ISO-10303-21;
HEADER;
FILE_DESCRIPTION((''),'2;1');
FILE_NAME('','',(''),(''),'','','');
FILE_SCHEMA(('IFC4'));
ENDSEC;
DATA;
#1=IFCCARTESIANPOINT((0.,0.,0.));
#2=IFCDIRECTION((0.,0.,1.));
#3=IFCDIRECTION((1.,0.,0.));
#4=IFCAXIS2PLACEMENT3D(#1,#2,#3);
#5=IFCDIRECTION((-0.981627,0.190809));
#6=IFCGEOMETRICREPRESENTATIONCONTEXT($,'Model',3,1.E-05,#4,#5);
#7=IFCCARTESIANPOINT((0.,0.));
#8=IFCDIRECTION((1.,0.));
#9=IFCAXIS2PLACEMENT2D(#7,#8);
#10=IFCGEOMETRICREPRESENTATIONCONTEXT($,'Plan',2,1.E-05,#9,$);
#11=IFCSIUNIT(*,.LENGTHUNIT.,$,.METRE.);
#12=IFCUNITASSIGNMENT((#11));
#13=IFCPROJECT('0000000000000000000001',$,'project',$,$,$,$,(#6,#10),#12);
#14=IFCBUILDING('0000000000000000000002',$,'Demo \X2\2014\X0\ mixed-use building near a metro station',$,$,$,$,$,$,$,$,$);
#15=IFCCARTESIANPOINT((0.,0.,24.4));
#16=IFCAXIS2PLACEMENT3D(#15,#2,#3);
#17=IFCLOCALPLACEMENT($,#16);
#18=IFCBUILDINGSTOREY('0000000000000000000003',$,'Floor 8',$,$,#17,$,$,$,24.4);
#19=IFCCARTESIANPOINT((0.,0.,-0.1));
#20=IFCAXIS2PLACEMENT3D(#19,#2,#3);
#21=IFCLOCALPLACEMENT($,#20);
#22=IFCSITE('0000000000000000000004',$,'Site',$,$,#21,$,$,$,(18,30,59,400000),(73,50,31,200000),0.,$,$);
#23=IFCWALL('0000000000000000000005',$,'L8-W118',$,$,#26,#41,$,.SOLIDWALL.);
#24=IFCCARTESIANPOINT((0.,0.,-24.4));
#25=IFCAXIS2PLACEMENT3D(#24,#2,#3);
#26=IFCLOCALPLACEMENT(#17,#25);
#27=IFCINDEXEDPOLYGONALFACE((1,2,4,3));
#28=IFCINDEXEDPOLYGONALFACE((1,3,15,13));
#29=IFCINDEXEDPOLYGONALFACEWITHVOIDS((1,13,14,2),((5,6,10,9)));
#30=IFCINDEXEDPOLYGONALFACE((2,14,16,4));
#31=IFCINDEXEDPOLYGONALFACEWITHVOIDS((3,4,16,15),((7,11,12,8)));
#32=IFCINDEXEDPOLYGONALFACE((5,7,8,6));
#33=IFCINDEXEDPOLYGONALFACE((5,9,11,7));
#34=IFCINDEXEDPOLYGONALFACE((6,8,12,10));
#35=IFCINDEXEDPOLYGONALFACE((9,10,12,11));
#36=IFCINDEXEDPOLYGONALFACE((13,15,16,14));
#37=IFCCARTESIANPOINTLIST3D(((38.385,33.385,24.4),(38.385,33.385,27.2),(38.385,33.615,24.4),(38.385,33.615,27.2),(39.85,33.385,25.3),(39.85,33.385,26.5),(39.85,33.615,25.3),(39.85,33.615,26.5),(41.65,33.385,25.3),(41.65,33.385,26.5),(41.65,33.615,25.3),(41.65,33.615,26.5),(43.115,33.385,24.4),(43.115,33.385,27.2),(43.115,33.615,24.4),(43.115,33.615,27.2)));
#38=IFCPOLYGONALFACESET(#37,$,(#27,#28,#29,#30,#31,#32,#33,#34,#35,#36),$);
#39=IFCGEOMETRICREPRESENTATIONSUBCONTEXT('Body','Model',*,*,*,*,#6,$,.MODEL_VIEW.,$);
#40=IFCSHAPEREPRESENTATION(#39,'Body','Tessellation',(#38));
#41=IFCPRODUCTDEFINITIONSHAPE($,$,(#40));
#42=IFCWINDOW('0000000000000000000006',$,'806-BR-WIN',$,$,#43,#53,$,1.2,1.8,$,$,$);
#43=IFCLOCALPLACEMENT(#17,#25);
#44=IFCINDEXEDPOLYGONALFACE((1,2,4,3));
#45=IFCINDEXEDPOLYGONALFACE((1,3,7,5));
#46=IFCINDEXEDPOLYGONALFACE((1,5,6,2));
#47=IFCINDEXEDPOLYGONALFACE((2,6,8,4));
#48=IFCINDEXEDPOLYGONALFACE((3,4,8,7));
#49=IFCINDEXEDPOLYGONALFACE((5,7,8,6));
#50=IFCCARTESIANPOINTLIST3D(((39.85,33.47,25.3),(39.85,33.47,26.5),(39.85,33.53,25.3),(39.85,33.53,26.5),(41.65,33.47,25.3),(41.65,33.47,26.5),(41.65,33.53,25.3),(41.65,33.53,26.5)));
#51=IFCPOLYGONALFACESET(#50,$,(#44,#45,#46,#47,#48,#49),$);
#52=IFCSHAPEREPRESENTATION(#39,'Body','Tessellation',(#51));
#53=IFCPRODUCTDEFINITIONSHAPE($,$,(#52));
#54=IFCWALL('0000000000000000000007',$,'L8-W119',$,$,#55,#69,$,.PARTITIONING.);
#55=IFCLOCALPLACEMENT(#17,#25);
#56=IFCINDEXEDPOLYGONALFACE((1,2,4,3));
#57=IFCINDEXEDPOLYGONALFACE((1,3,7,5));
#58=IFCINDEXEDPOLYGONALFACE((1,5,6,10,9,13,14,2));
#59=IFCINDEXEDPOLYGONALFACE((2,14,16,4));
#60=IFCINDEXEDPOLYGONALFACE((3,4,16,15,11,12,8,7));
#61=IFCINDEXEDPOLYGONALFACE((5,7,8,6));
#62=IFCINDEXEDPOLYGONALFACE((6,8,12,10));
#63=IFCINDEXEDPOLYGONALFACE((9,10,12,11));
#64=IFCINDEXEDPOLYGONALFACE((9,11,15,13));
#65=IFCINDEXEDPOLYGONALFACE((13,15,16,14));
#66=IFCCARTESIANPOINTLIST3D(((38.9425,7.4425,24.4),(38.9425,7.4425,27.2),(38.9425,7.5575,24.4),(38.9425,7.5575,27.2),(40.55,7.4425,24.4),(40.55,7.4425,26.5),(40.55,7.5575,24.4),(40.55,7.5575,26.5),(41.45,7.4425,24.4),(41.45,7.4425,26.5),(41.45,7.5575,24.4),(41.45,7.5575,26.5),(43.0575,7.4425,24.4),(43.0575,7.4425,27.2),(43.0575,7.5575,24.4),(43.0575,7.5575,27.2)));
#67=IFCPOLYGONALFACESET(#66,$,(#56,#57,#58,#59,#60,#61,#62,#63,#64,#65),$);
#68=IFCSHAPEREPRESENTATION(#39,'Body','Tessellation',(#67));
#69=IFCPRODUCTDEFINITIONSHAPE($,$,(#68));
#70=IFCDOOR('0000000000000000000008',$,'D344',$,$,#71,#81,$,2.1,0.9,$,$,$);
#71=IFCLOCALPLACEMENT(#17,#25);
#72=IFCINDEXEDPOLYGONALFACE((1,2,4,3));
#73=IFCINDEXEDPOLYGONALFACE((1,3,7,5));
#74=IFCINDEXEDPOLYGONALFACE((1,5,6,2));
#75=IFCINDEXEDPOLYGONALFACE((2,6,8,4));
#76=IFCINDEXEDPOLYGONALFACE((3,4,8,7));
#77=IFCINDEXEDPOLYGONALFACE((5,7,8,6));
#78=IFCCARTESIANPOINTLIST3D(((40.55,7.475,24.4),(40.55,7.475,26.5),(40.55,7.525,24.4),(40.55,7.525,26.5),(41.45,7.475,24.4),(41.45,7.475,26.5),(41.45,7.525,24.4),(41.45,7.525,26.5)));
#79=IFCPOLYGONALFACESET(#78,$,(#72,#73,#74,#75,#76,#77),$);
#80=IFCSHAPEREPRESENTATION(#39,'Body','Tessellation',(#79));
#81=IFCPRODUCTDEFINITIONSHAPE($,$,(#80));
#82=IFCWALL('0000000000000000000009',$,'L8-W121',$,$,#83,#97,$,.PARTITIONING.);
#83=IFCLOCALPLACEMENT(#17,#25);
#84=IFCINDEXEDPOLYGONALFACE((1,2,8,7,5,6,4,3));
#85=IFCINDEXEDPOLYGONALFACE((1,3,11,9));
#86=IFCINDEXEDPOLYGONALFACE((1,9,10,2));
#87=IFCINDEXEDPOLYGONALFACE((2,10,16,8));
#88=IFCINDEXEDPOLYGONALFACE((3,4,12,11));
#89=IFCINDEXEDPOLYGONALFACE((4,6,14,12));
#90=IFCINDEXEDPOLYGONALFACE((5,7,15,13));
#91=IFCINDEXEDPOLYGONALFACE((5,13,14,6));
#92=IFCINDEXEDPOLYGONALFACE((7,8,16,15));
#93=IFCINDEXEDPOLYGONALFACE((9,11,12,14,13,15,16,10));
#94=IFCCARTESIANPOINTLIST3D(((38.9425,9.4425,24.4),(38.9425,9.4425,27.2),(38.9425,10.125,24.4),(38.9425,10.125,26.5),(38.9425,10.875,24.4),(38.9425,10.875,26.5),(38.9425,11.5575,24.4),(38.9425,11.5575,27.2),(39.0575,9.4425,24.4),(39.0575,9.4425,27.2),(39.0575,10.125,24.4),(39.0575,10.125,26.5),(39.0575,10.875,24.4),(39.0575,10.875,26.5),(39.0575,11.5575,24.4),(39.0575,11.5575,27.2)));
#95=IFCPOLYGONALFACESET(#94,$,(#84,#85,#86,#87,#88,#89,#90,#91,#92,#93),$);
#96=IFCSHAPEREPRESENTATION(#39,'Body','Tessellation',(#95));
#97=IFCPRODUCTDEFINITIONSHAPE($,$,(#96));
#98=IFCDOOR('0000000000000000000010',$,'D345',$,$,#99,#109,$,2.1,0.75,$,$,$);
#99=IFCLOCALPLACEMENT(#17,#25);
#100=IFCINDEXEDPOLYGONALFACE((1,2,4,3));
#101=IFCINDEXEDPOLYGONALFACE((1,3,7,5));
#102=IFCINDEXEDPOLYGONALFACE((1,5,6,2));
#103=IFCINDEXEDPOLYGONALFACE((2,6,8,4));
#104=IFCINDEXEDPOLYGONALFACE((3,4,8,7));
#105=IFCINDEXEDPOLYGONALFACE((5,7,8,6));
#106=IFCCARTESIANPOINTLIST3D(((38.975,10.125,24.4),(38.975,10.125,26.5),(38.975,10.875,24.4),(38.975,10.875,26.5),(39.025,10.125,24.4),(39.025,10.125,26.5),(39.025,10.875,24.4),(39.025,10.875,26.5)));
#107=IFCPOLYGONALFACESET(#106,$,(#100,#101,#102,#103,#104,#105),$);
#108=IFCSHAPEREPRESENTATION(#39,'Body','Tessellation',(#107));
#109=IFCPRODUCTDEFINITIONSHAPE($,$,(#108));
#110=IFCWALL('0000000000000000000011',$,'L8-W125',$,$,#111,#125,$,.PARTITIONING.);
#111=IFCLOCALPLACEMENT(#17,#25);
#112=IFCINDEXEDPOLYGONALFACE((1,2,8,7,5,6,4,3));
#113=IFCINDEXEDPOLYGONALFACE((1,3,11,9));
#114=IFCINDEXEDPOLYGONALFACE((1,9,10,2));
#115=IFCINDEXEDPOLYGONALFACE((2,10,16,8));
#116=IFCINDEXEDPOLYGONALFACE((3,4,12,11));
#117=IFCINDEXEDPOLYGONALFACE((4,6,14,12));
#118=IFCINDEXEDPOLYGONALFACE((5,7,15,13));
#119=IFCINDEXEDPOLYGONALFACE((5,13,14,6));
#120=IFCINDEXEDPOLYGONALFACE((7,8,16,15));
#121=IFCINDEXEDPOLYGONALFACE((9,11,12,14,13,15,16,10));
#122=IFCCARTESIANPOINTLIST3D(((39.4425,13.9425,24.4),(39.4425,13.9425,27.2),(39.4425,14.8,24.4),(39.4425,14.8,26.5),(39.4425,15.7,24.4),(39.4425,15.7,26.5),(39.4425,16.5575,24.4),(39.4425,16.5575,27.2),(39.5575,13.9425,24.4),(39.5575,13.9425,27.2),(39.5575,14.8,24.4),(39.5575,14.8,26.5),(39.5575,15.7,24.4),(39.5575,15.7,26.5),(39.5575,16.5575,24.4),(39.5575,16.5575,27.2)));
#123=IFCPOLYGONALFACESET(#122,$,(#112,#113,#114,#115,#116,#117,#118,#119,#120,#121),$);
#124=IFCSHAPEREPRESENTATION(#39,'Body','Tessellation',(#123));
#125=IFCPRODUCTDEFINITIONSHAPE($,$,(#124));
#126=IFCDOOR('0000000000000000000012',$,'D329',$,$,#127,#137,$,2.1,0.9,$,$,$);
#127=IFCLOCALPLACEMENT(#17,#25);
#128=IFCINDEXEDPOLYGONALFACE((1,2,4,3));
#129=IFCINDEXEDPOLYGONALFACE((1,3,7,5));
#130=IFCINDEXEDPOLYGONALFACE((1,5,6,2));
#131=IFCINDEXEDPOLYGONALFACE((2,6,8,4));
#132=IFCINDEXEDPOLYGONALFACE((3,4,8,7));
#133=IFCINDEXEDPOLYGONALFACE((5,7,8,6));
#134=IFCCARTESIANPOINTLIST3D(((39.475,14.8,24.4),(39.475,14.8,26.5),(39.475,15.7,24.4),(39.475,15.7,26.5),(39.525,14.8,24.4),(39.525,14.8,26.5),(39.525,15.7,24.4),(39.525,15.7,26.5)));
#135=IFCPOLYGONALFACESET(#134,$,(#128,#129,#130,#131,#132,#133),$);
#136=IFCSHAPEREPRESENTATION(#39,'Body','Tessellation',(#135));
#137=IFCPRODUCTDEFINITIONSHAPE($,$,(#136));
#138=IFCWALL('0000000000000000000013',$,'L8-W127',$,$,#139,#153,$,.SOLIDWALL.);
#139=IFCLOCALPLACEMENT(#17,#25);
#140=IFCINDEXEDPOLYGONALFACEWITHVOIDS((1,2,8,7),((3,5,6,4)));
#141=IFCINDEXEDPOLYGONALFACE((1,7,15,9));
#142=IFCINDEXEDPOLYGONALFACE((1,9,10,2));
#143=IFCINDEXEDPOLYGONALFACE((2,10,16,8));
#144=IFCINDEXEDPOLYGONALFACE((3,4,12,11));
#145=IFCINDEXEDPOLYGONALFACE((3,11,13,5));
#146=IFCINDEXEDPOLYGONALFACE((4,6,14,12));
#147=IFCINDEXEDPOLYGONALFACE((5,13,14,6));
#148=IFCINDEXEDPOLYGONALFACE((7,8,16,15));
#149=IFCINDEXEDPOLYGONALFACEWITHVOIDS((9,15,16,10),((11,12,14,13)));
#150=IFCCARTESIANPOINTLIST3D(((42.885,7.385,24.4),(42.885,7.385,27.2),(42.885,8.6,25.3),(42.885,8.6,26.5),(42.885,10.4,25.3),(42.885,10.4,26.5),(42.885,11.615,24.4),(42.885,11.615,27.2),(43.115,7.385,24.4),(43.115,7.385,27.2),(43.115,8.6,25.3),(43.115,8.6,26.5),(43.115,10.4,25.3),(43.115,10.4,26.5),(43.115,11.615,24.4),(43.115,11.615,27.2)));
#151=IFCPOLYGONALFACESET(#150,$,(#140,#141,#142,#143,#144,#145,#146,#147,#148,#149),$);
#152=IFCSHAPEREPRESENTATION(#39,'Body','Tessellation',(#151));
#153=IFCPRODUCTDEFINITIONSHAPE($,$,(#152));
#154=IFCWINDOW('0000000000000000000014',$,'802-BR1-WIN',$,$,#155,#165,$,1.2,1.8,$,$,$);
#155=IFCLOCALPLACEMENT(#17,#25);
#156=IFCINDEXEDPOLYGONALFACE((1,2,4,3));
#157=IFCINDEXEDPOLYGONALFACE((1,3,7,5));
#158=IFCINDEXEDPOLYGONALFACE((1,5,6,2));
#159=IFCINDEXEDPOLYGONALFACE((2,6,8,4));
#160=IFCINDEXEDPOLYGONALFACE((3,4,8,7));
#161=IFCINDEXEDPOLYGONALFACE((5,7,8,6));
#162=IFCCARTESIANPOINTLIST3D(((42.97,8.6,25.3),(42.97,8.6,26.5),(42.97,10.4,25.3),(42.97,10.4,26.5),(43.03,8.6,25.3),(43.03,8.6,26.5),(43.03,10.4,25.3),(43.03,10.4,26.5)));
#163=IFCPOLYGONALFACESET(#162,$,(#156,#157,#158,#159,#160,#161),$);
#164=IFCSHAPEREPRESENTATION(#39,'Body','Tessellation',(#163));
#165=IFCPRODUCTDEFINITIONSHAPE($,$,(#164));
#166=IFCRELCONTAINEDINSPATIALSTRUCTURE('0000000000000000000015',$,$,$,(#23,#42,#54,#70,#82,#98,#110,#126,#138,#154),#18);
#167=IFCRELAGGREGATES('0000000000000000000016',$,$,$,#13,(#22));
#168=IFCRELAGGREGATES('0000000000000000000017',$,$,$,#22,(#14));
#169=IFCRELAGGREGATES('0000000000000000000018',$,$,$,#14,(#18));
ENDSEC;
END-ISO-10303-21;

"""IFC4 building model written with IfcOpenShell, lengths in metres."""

from ifc_helpers import new_model, si_unit, direction, frame, origin_with_axes, origin_2d_with_axis, place, context, subcontext, project, spatial, line, indexed_curve, outline, extrude, element, fill, save


model = new_model("IFC4")

# Units and contexts
model_context = context("Model", 3, precision=1e-05, world=origin_with_axes(), true_north=direction((-0.981627, 0.190809)))
plan_context = context("Plan", 2, precision=1e-05, world=origin_2d_with_axis())
body_context = subcontext(model_context, "Body", "Model", "MODEL_VIEW")
ifc_project = project(units=[si_unit("LENGTHUNIT", "METRE")], contexts=[model_context, plan_context])

# Site, building, storey
site_placement = place(None, frame((0.0, 0.0, -0.1), z_axis=(0.0, 0.0, 1.0), x_axis=(1.0, 0.0, 0.0)))
site = spatial("IfcSite", under=ifc_project, at=site_placement, Name="Site", RefLatitude=(18, 30, 59, 400000), RefLongitude=(73, 50, 31, 200000), RefElevation=0.0)
building = spatial("IfcBuilding", under=site, Name="Demo — mixed-use building near a metro station")
storey_placement = place(None, frame((0.0, 0.0, 24.4), z_axis=(0.0, 0.0, 1.0), x_axis=(1.0, 0.0, 0.0)))
storey = spatial("IfcBuildingStorey", under=building, at=storey_placement, Name="Floor 8", Elevation=24.4)

# Wall, opening, window
wall_1_placement = place(storey_placement, frame((0.0, 0.0, -24.4), z_axis=(0.0, 0.0, 1.0), x_axis=(1.0, 0.0, 0.0)))
wall_1 = element("IfcWall", 1, at=wall_1_placement, inside=storey, Name="L8-W118", PredefinedType="SOLIDWALL", context=body_context, shape_type="SweptSolid", body=[
    extrude(outline(indexed_curve([(43.115, 33.385), (38.385, 33.385), (38.385, 33.615), (43.115, 33.615)], segments=[line(1, 2, 3, 4, 1)])), frame((0.0, 0.0, 24.4), z_axis=(0.0, 0.0, 1.0), x_axis=(1.0, 0.0, 0.0)), (0.0, 0.0, 1.0), 2.8),
])
opening_1_placement = place(wall_1_placement, origin_with_axes())
opening_1 = element("IfcOpeningElement", 2, at=opening_1_placement, cuts=wall_1, context=body_context, shape_type="SweptSolid", body=[
    extrude(outline(indexed_curve([(41.65, 33.335), (39.85, 33.335), (39.85, 33.665), (41.65, 33.665)], segments=[line(1, 2, 3, 4, 1)])), frame((0.0, 0.0, 25.3), z_axis=(0.0, 0.0, 1.0), x_axis=(1.0, 0.0, 0.0)), (0.0, 0.0, 1.0), 1.2),
])
window_1_placement = place(storey_placement, frame((0.0, 0.0, -24.4), z_axis=(0.0, 0.0, 1.0), x_axis=(1.0, 0.0, 0.0)))
window_1 = element("IfcWindow", 3, at=window_1_placement, inside=storey, Name="806-BR-WIN", OverallHeight=1.2, OverallWidth=1.8, context=body_context, shape_type="SweptSolid", body=[
    extrude(outline(indexed_curve([(41.65, 33.47), (39.85, 33.47), (39.85, 33.53), (41.65, 33.53)], segments=[line(1, 2, 3, 4, 1)])), frame((0.0, 0.0, 25.3), z_axis=(0.0, 0.0, 1.0), x_axis=(1.0, 0.0, 0.0)), (0.0, 0.0, 1.0), 1.2),
])
fill(opening_1, window_1)

# Wall, opening, door
wall_2_placement = place(storey_placement, frame((0.0, 0.0, -24.4), z_axis=(0.0, 0.0, 1.0), x_axis=(1.0, 0.0, 0.0)))
wall_2 = element("IfcWall", 4, at=wall_2_placement, inside=storey, Name="L8-W119", PredefinedType="PARTITIONING", context=body_context, shape_type="SweptSolid", body=[
    extrude(outline(indexed_curve([(43.0575, 7.4425), (38.9425, 7.4425), (38.9425, 7.5575), (43.0575, 7.5575)], segments=[line(1, 2, 3, 4, 1)])), frame((0.0, 0.0, 24.4), z_axis=(0.0, 0.0, 1.0), x_axis=(1.0, 0.0, 0.0)), (0.0, 0.0, 1.0), 2.8),
])
opening_2_placement = place(wall_2_placement, origin_with_axes())
opening_2 = element("IfcOpeningElement", 5, at=opening_2_placement, cuts=wall_2, context=body_context, shape_type="SweptSolid", body=[
    extrude(outline(indexed_curve([(41.45, 7.3925), (40.55, 7.3925), (40.55, 7.6075), (41.45, 7.6075)], segments=[line(1, 2, 3, 4, 1)])), frame((0.0, 0.0, 24.4), z_axis=(0.0, 0.0, 1.0), x_axis=(1.0, 0.0, 0.0)), (0.0, 0.0, 1.0), 2.1),
])
door_1_placement = place(storey_placement, frame((0.0, 0.0, -24.4), z_axis=(0.0, 0.0, 1.0), x_axis=(1.0, 0.0, 0.0)))
door_1 = element("IfcDoor", 6, at=door_1_placement, inside=storey, Name="D344", OverallHeight=2.1, OverallWidth=0.9, context=body_context, shape_type="SweptSolid", body=[
    extrude(outline(indexed_curve([(41.45, 7.475), (40.55, 7.475), (40.55, 7.525), (41.45, 7.525)], segments=[line(1, 2, 3, 4, 1)])), frame((0.0, 0.0, 24.4), z_axis=(0.0, 0.0, 1.0), x_axis=(1.0, 0.0, 0.0)), (0.0, 0.0, 1.0), 2.1),
])
fill(opening_2, door_1)

# Wall, opening, door
wall_3_placement = place(storey_placement, frame((0.0, 0.0, -24.4), z_axis=(0.0, 0.0, 1.0), x_axis=(1.0, 0.0, 0.0)))
wall_3 = element("IfcWall", 7, at=wall_3_placement, inside=storey, Name="L8-W121", PredefinedType="PARTITIONING", context=body_context, shape_type="SweptSolid", body=[
    extrude(outline(indexed_curve([(39.0575, 11.5575), (39.0575, 9.4425), (38.9425, 9.4425), (38.9425, 11.5575)], segments=[line(1, 2, 3, 4, 1)])), frame((0.0, 0.0, 24.4), z_axis=(0.0, 0.0, 1.0), x_axis=(1.0, 0.0, 0.0)), (0.0, 0.0, 1.0), 2.8),
])
opening_3_placement = place(wall_3_placement, origin_with_axes())
opening_3 = element("IfcOpeningElement", 8, at=opening_3_placement, cuts=wall_3, context=body_context, shape_type="SweptSolid", body=[
    extrude(outline(indexed_curve([(39.1075, 10.875), (39.1075, 10.125), (38.8925, 10.125), (38.8925, 10.875)], segments=[line(1, 2, 3, 4, 1)])), frame((0.0, 0.0, 24.4), z_axis=(0.0, 0.0, 1.0), x_axis=(1.0, 0.0, 0.0)), (0.0, 0.0, 1.0), 2.1),
])
door_2_placement = place(storey_placement, frame((0.0, 0.0, -24.4), z_axis=(0.0, 0.0, 1.0), x_axis=(1.0, 0.0, 0.0)))
door_2 = element("IfcDoor", 9, at=door_2_placement, inside=storey, Name="D345", OverallHeight=2.1, OverallWidth=0.75, context=body_context, shape_type="SweptSolid", body=[
    extrude(outline(indexed_curve([(39.025, 10.875), (39.025, 10.125), (38.975, 10.125), (38.975, 10.875)], segments=[line(1, 2, 3, 4, 1)])), frame((0.0, 0.0, 24.4), z_axis=(0.0, 0.0, 1.0), x_axis=(1.0, 0.0, 0.0)), (0.0, 0.0, 1.0), 2.1),
])
fill(opening_3, door_2)

# Wall, opening, door
wall_4_placement = place(storey_placement, frame((0.0, 0.0, -24.4), z_axis=(0.0, 0.0, 1.0), x_axis=(1.0, 0.0, 0.0)))
wall_4 = element("IfcWall", 10, at=wall_4_placement, inside=storey, Name="L8-W125", PredefinedType="PARTITIONING", context=body_context, shape_type="SweptSolid", body=[
    extrude(outline(indexed_curve([(39.4425, 13.9425), (39.4425, 16.5575), (39.5575, 16.5575), (39.5575, 13.9425)], segments=[line(1, 2, 3, 4, 1)])), frame((0.0, 0.0, 24.4), z_axis=(0.0, 0.0, 1.0), x_axis=(1.0, 0.0, 0.0)), (0.0, 0.0, 1.0), 2.8),
])
opening_4_placement = place(wall_4_placement, origin_with_axes())
opening_4 = element("IfcOpeningElement", 11, at=opening_4_placement, cuts=wall_4, context=body_context, shape_type="SweptSolid", body=[
    extrude(outline(indexed_curve([(39.3925, 14.8), (39.3925, 15.7), (39.6075, 15.7), (39.6075, 14.8)], segments=[line(1, 2, 3, 4, 1)])), frame((0.0, 0.0, 24.4), z_axis=(0.0, 0.0, 1.0), x_axis=(1.0, 0.0, 0.0)), (0.0, 0.0, 1.0), 2.1),
])
door_3_placement = place(storey_placement, frame((0.0, 0.0, -24.4), z_axis=(0.0, 0.0, 1.0), x_axis=(1.0, 0.0, 0.0)))
door_3 = element("IfcDoor", 12, at=door_3_placement, inside=storey, Name="D329", OverallHeight=2.1, OverallWidth=0.9, context=body_context, shape_type="SweptSolid", body=[
    extrude(outline(indexed_curve([(39.475, 14.8), (39.475, 15.7), (39.525, 15.7), (39.525, 14.8)], segments=[line(1, 2, 3, 4, 1)])), frame((0.0, 0.0, 24.4), z_axis=(0.0, 0.0, 1.0), x_axis=(1.0, 0.0, 0.0)), (0.0, 0.0, 1.0), 2.1),
])
fill(opening_4, door_3)

# Wall, opening, window
wall_5_placement = place(storey_placement, frame((0.0, 0.0, -24.4), z_axis=(0.0, 0.0, 1.0), x_axis=(1.0, 0.0, 0.0)))
wall_5 = element("IfcWall", 13, at=wall_5_placement, inside=storey, Name="L8-W127", PredefinedType="SOLIDWALL", context=body_context, shape_type="SweptSolid", body=[
    extrude(outline(indexed_curve([(42.885, 7.385), (42.885, 11.615), (43.115, 11.615), (43.115, 7.385)], segments=[line(1, 2, 3, 4, 1)])), frame((0.0, 0.0, 24.4), z_axis=(0.0, 0.0, 1.0), x_axis=(1.0, 0.0, 0.0)), (0.0, 0.0, 1.0), 2.8),
])
opening_5_placement = place(wall_5_placement, origin_with_axes())
opening_5 = element("IfcOpeningElement", 14, at=opening_5_placement, cuts=wall_5, context=body_context, shape_type="SweptSolid", body=[
    extrude(outline(indexed_curve([(42.835, 8.6), (42.835, 10.4), (43.165, 10.4), (43.165, 8.6)], segments=[line(1, 2, 3, 4, 1)])), frame((0.0, 0.0, 25.3), z_axis=(0.0, 0.0, 1.0), x_axis=(1.0, 0.0, 0.0)), (0.0, 0.0, 1.0), 1.2),
])
window_2_placement = place(storey_placement, frame((0.0, 0.0, -24.4), z_axis=(0.0, 0.0, 1.0), x_axis=(1.0, 0.0, 0.0)))
window_2 = element("IfcWindow", 15, at=window_2_placement, inside=storey, Name="802-BR1-WIN", OverallHeight=1.2, OverallWidth=1.8, context=body_context, shape_type="SweptSolid", body=[
    extrude(outline(indexed_curve([(42.97, 8.6), (42.97, 10.4), (43.03, 10.4), (43.03, 8.6)], segments=[line(1, 2, 3, 4, 1)])), frame((0.0, 0.0, 25.3), z_axis=(0.0, 0.0, 1.0), x_axis=(1.0, 0.0, 0.0)), (0.0, 0.0, 1.0), 1.2),
])
fill(opening_5, window_2)

save(model, "model.ifc")
